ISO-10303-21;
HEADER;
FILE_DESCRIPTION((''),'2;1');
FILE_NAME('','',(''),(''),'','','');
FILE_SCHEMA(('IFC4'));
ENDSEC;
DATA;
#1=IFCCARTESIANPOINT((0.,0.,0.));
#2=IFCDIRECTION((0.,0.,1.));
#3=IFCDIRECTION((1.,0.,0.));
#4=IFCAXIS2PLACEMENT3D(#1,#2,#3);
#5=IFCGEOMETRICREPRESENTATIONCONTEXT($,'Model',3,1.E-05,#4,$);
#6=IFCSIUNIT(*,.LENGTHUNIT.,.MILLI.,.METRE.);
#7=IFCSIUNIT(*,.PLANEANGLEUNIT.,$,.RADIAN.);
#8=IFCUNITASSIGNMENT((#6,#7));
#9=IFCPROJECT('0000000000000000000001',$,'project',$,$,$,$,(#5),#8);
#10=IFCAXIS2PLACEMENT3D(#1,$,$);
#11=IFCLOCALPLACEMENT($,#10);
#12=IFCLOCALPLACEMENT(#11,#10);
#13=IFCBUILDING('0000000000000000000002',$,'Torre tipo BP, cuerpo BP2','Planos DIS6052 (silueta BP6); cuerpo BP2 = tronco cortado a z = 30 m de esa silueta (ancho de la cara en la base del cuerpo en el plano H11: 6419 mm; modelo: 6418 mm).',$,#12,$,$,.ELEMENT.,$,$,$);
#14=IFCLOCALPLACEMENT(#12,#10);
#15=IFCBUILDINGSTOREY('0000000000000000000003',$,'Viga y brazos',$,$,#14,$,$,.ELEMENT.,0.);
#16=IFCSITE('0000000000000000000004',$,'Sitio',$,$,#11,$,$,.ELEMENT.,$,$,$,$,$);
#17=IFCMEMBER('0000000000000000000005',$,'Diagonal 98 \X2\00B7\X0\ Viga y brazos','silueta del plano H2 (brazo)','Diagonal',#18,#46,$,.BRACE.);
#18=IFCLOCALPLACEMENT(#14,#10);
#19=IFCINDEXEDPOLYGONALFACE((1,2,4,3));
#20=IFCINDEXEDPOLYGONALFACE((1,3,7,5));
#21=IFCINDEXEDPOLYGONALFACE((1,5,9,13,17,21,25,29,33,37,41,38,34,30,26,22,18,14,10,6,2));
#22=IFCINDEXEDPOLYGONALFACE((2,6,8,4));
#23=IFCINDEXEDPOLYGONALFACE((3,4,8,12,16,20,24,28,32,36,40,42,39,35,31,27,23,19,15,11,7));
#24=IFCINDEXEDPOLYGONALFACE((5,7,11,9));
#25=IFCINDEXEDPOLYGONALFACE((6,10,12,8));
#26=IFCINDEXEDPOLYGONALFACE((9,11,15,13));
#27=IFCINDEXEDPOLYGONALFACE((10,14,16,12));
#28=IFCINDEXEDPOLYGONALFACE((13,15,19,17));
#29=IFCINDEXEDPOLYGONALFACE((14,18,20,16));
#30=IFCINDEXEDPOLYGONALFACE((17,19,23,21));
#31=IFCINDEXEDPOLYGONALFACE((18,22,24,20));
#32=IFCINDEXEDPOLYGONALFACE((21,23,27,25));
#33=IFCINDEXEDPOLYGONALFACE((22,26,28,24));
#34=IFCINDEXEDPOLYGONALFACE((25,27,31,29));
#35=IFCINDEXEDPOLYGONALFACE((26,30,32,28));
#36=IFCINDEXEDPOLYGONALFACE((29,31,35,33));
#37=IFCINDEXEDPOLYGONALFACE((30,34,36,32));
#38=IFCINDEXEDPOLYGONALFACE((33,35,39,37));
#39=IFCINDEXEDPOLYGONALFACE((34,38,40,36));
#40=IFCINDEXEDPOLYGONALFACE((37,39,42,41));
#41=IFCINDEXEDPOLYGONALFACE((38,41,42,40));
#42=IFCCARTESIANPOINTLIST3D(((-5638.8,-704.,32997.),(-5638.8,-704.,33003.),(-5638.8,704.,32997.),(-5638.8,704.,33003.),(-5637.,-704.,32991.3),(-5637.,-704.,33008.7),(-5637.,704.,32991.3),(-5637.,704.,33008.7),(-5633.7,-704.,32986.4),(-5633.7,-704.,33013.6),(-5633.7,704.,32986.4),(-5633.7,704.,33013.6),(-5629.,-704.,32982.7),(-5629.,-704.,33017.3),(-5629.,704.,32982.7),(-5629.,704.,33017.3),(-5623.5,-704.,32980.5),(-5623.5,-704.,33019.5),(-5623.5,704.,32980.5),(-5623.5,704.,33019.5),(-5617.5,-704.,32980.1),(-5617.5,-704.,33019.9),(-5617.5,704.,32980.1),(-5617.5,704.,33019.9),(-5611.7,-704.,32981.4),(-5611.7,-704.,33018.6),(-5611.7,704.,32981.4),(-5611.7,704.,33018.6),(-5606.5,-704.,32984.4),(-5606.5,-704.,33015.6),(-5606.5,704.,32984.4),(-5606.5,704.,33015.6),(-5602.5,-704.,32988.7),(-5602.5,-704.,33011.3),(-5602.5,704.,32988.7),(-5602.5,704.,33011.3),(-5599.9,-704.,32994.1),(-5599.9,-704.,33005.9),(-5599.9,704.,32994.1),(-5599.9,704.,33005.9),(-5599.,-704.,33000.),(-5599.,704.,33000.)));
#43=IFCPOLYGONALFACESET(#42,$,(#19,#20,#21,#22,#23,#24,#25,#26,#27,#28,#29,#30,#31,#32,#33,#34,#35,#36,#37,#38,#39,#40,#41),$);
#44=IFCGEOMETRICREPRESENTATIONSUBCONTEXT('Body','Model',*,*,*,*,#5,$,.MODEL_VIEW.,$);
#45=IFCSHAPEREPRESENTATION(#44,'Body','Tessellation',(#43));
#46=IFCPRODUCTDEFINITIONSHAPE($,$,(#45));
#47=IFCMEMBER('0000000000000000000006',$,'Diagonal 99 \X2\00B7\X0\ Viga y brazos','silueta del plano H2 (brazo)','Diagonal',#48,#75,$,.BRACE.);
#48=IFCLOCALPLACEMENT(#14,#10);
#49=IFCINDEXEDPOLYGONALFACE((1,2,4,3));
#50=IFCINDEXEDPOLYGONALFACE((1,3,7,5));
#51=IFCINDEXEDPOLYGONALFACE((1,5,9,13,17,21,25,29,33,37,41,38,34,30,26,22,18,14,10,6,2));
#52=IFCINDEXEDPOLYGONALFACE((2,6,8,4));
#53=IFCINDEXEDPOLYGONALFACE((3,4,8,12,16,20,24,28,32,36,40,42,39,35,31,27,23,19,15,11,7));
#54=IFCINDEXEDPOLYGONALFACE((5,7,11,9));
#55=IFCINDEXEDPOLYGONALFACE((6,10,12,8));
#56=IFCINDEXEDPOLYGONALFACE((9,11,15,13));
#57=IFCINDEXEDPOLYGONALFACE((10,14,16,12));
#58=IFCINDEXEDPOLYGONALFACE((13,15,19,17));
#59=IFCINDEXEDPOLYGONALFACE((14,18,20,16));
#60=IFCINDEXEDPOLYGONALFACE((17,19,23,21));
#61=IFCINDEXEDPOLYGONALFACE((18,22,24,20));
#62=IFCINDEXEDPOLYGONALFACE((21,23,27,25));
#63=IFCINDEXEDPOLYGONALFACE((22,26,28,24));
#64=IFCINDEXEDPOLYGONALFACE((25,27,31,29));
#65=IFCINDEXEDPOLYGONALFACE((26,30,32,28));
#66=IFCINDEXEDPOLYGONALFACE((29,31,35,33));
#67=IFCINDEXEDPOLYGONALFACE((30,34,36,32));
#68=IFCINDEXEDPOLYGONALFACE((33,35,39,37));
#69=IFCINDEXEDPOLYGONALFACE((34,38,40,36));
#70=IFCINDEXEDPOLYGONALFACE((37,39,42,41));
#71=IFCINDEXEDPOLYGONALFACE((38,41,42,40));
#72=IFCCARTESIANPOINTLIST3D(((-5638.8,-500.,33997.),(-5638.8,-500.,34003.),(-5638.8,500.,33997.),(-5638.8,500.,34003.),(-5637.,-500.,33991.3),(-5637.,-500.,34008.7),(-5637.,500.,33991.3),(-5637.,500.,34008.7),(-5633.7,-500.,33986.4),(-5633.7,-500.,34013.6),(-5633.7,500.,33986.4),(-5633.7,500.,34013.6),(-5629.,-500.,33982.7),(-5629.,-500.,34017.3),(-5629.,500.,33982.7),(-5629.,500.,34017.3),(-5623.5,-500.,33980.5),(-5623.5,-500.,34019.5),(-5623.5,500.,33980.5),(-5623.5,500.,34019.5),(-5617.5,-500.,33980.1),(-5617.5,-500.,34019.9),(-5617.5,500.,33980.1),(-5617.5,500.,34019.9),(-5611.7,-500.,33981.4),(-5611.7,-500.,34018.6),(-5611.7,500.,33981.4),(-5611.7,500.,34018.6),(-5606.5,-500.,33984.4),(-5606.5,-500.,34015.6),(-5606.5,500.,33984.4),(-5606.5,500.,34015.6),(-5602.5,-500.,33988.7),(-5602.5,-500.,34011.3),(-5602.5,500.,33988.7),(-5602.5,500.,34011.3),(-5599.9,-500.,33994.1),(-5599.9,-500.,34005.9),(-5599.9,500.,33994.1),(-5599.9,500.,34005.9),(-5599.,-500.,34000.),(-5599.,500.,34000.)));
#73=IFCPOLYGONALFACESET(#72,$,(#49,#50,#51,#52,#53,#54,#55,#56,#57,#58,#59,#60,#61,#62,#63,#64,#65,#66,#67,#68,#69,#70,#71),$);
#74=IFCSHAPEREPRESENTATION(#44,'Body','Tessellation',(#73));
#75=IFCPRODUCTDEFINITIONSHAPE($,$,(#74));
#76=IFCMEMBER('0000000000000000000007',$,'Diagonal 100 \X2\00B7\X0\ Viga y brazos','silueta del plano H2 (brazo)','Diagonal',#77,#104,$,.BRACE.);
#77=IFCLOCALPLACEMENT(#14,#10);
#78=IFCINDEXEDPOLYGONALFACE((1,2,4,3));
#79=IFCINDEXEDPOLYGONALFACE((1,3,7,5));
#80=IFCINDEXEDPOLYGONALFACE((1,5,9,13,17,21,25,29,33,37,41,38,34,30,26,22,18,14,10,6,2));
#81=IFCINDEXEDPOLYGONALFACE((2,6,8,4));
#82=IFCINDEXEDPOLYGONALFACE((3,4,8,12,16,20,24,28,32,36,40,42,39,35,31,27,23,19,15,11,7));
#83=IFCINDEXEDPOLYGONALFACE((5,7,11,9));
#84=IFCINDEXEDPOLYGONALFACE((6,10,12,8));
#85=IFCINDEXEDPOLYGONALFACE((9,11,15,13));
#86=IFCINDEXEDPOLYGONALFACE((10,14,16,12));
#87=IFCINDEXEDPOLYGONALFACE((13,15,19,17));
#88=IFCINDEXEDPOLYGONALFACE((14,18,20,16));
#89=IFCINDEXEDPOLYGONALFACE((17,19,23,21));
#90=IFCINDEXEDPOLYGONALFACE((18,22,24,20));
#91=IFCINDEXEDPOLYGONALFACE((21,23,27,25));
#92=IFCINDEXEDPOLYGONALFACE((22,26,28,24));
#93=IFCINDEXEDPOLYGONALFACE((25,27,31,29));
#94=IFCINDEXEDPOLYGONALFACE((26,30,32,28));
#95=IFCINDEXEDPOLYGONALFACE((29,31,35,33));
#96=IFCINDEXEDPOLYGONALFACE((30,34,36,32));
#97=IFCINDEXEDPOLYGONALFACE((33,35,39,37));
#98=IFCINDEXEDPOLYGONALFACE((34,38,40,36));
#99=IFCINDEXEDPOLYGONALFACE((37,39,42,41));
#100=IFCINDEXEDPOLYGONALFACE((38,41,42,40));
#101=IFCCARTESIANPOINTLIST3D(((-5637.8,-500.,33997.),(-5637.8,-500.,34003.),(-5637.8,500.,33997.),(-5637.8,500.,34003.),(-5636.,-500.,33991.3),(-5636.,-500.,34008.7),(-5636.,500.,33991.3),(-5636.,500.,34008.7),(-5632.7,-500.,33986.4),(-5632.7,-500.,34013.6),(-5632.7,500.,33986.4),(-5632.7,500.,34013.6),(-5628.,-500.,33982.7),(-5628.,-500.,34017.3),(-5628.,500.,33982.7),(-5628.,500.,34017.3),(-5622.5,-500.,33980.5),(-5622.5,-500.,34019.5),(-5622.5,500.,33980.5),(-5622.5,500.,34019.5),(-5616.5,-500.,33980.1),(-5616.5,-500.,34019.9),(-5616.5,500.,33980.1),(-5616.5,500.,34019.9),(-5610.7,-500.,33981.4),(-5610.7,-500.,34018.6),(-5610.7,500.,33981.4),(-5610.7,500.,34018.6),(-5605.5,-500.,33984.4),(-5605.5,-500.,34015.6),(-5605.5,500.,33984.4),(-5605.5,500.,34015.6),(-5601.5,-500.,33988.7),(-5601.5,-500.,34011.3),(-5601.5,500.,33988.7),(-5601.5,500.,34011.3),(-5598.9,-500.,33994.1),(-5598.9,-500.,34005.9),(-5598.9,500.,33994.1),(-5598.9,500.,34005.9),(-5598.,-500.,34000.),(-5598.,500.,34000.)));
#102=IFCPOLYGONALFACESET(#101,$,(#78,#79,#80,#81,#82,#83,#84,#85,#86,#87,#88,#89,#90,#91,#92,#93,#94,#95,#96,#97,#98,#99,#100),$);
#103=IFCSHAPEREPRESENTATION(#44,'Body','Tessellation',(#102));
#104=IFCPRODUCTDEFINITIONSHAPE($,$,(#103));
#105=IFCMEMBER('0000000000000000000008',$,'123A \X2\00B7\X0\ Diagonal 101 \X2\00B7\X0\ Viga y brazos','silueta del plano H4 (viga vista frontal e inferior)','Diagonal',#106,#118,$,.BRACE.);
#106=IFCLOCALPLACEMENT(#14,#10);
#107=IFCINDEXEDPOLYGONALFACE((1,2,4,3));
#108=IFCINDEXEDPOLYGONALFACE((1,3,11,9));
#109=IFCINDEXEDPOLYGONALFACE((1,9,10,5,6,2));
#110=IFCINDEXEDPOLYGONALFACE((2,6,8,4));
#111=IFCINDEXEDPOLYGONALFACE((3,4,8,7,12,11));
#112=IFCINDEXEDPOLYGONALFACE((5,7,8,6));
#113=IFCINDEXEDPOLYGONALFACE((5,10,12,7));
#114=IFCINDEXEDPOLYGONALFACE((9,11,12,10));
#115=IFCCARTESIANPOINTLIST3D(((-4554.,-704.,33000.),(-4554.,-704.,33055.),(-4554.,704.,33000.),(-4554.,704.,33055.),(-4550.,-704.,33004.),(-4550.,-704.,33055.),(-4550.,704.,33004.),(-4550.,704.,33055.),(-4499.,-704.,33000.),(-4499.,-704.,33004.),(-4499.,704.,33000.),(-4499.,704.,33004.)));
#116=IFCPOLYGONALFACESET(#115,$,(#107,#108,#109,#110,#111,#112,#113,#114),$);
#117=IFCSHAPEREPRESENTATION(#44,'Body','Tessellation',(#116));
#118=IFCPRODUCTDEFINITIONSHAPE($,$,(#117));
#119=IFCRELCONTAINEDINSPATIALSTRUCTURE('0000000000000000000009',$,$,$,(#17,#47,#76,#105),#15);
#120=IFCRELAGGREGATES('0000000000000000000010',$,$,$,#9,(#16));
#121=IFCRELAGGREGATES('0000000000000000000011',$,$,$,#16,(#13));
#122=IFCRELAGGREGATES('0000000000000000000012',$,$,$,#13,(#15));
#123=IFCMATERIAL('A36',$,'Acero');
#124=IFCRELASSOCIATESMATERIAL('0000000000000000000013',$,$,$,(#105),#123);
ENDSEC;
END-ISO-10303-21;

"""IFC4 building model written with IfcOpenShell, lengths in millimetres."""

from ifc_helpers import new_model, si_unit, frame, frame_2d, origin, origin_with_axes, place, context, subcontext, project, spatial, circle, l_section, extrude, material, element, save


model = new_model("IFC4")

# Units and contexts
model_context = context("Model", 3, precision=1e-05, world=origin_with_axes())
body_context = subcontext(model_context, "Body", "Model", "MODEL_VIEW")
ifc_project = project(units=[si_unit("LENGTHUNIT", "METRE", prefix="MILLI"), si_unit("PLANEANGLEUNIT", "RADIAN")], contexts=[model_context])

# Site, building, storey
site_placement = place(None, origin())
site = spatial("IfcSite", under=ifc_project, at=site_placement, Name="Sitio", CompositionType="ELEMENT")
building_placement = place(site_placement, origin())
building = spatial("IfcBuilding", under=site, at=building_placement, Name="Torre tipo BP, cuerpo BP2", Description="Planos DIS6052 (silueta BP6); cuerpo BP2 = tronco cortado a z = 30 m de esa silueta (ancho de la cara en la base del cuerpo en el plano H11: 6419 mm; modelo: 6418 mm).", CompositionType="ELEMENT")
storey_placement = place(building_placement, origin())
storey = spatial("IfcBuildingStorey", under=building, at=storey_placement, Name="Viga y brazos", CompositionType="ELEMENT", Elevation=0.0)

# Members
ifc_material_1 = material(Name="A36", Category="Acero")
for number, where, z_axis, x_axis, name in (
    (1, (-5619.0, 704.0, 33000.0), (0.0, -1.0, 0.0), (1.0, 0.0, 0.0), "Diagonal 98 · Viga y brazos"),
):
    element("IfcMember", number, at=place(storey_placement, frame(where, z_axis=z_axis, x_axis=x_axis)), inside=storey, Name=name, Description="silueta del plano H2 (brazo)", ObjectType="Diagonal", PredefinedType="BRACE", context=body_context, shape_type="SweptSolid", body=[
        extrude(circle(Radius=20.0), None, (0.0, 0.0, 1.0), 1408.0),
    ])
for number, where, z_axis, x_axis, name in (
    (2, (-5619.0, 500.0, 34000.0), (0.0, -1.0, 0.0), (1.0, 0.0, 0.0), "Diagonal 99 · Viga y brazos"),
    (3, (-5618.0, 500.0, 34000.0), (0.0, -1.0, 0.0), (1.0, 0.0, 0.0), "Diagonal 100 · Viga y brazos"),
):
    element("IfcMember", number, at=place(storey_placement, frame(where, z_axis=z_axis, x_axis=x_axis)), inside=storey, Name=name, Description="silueta del plano H2 (brazo)", ObjectType="Diagonal", PredefinedType="BRACE", context=body_context, shape_type="SweptSolid", body=[
        extrude(circle(Radius=20.0), None, (0.0, 0.0, 1.0), 1000.0),
    ])
member_1_placement = place(storey_placement, frame((-4554.0, 704.0, 33000.0), z_axis=(0.0, -1.0, 0.0), x_axis=(1.0, 0.0, 0.0)))
element("IfcMember", 4, at=member_1_placement, inside=storey, material=ifc_material_1, Name="123A · Diagonal 101 · Viga y brazos", Description="silueta del plano H4 (viga vista frontal e inferior)", ObjectType="Diagonal", PredefinedType="BRACE", context=body_context, shape_type="SweptSolid", body=[
    extrude(l_section(Depth=55.0, Width=55.0, Thickness=4.0, at=frame_2d((27.5, 27.5))), None, (0.0, 0.0, 1.0), 1408.0),
])

save(model, "model.ifc")
